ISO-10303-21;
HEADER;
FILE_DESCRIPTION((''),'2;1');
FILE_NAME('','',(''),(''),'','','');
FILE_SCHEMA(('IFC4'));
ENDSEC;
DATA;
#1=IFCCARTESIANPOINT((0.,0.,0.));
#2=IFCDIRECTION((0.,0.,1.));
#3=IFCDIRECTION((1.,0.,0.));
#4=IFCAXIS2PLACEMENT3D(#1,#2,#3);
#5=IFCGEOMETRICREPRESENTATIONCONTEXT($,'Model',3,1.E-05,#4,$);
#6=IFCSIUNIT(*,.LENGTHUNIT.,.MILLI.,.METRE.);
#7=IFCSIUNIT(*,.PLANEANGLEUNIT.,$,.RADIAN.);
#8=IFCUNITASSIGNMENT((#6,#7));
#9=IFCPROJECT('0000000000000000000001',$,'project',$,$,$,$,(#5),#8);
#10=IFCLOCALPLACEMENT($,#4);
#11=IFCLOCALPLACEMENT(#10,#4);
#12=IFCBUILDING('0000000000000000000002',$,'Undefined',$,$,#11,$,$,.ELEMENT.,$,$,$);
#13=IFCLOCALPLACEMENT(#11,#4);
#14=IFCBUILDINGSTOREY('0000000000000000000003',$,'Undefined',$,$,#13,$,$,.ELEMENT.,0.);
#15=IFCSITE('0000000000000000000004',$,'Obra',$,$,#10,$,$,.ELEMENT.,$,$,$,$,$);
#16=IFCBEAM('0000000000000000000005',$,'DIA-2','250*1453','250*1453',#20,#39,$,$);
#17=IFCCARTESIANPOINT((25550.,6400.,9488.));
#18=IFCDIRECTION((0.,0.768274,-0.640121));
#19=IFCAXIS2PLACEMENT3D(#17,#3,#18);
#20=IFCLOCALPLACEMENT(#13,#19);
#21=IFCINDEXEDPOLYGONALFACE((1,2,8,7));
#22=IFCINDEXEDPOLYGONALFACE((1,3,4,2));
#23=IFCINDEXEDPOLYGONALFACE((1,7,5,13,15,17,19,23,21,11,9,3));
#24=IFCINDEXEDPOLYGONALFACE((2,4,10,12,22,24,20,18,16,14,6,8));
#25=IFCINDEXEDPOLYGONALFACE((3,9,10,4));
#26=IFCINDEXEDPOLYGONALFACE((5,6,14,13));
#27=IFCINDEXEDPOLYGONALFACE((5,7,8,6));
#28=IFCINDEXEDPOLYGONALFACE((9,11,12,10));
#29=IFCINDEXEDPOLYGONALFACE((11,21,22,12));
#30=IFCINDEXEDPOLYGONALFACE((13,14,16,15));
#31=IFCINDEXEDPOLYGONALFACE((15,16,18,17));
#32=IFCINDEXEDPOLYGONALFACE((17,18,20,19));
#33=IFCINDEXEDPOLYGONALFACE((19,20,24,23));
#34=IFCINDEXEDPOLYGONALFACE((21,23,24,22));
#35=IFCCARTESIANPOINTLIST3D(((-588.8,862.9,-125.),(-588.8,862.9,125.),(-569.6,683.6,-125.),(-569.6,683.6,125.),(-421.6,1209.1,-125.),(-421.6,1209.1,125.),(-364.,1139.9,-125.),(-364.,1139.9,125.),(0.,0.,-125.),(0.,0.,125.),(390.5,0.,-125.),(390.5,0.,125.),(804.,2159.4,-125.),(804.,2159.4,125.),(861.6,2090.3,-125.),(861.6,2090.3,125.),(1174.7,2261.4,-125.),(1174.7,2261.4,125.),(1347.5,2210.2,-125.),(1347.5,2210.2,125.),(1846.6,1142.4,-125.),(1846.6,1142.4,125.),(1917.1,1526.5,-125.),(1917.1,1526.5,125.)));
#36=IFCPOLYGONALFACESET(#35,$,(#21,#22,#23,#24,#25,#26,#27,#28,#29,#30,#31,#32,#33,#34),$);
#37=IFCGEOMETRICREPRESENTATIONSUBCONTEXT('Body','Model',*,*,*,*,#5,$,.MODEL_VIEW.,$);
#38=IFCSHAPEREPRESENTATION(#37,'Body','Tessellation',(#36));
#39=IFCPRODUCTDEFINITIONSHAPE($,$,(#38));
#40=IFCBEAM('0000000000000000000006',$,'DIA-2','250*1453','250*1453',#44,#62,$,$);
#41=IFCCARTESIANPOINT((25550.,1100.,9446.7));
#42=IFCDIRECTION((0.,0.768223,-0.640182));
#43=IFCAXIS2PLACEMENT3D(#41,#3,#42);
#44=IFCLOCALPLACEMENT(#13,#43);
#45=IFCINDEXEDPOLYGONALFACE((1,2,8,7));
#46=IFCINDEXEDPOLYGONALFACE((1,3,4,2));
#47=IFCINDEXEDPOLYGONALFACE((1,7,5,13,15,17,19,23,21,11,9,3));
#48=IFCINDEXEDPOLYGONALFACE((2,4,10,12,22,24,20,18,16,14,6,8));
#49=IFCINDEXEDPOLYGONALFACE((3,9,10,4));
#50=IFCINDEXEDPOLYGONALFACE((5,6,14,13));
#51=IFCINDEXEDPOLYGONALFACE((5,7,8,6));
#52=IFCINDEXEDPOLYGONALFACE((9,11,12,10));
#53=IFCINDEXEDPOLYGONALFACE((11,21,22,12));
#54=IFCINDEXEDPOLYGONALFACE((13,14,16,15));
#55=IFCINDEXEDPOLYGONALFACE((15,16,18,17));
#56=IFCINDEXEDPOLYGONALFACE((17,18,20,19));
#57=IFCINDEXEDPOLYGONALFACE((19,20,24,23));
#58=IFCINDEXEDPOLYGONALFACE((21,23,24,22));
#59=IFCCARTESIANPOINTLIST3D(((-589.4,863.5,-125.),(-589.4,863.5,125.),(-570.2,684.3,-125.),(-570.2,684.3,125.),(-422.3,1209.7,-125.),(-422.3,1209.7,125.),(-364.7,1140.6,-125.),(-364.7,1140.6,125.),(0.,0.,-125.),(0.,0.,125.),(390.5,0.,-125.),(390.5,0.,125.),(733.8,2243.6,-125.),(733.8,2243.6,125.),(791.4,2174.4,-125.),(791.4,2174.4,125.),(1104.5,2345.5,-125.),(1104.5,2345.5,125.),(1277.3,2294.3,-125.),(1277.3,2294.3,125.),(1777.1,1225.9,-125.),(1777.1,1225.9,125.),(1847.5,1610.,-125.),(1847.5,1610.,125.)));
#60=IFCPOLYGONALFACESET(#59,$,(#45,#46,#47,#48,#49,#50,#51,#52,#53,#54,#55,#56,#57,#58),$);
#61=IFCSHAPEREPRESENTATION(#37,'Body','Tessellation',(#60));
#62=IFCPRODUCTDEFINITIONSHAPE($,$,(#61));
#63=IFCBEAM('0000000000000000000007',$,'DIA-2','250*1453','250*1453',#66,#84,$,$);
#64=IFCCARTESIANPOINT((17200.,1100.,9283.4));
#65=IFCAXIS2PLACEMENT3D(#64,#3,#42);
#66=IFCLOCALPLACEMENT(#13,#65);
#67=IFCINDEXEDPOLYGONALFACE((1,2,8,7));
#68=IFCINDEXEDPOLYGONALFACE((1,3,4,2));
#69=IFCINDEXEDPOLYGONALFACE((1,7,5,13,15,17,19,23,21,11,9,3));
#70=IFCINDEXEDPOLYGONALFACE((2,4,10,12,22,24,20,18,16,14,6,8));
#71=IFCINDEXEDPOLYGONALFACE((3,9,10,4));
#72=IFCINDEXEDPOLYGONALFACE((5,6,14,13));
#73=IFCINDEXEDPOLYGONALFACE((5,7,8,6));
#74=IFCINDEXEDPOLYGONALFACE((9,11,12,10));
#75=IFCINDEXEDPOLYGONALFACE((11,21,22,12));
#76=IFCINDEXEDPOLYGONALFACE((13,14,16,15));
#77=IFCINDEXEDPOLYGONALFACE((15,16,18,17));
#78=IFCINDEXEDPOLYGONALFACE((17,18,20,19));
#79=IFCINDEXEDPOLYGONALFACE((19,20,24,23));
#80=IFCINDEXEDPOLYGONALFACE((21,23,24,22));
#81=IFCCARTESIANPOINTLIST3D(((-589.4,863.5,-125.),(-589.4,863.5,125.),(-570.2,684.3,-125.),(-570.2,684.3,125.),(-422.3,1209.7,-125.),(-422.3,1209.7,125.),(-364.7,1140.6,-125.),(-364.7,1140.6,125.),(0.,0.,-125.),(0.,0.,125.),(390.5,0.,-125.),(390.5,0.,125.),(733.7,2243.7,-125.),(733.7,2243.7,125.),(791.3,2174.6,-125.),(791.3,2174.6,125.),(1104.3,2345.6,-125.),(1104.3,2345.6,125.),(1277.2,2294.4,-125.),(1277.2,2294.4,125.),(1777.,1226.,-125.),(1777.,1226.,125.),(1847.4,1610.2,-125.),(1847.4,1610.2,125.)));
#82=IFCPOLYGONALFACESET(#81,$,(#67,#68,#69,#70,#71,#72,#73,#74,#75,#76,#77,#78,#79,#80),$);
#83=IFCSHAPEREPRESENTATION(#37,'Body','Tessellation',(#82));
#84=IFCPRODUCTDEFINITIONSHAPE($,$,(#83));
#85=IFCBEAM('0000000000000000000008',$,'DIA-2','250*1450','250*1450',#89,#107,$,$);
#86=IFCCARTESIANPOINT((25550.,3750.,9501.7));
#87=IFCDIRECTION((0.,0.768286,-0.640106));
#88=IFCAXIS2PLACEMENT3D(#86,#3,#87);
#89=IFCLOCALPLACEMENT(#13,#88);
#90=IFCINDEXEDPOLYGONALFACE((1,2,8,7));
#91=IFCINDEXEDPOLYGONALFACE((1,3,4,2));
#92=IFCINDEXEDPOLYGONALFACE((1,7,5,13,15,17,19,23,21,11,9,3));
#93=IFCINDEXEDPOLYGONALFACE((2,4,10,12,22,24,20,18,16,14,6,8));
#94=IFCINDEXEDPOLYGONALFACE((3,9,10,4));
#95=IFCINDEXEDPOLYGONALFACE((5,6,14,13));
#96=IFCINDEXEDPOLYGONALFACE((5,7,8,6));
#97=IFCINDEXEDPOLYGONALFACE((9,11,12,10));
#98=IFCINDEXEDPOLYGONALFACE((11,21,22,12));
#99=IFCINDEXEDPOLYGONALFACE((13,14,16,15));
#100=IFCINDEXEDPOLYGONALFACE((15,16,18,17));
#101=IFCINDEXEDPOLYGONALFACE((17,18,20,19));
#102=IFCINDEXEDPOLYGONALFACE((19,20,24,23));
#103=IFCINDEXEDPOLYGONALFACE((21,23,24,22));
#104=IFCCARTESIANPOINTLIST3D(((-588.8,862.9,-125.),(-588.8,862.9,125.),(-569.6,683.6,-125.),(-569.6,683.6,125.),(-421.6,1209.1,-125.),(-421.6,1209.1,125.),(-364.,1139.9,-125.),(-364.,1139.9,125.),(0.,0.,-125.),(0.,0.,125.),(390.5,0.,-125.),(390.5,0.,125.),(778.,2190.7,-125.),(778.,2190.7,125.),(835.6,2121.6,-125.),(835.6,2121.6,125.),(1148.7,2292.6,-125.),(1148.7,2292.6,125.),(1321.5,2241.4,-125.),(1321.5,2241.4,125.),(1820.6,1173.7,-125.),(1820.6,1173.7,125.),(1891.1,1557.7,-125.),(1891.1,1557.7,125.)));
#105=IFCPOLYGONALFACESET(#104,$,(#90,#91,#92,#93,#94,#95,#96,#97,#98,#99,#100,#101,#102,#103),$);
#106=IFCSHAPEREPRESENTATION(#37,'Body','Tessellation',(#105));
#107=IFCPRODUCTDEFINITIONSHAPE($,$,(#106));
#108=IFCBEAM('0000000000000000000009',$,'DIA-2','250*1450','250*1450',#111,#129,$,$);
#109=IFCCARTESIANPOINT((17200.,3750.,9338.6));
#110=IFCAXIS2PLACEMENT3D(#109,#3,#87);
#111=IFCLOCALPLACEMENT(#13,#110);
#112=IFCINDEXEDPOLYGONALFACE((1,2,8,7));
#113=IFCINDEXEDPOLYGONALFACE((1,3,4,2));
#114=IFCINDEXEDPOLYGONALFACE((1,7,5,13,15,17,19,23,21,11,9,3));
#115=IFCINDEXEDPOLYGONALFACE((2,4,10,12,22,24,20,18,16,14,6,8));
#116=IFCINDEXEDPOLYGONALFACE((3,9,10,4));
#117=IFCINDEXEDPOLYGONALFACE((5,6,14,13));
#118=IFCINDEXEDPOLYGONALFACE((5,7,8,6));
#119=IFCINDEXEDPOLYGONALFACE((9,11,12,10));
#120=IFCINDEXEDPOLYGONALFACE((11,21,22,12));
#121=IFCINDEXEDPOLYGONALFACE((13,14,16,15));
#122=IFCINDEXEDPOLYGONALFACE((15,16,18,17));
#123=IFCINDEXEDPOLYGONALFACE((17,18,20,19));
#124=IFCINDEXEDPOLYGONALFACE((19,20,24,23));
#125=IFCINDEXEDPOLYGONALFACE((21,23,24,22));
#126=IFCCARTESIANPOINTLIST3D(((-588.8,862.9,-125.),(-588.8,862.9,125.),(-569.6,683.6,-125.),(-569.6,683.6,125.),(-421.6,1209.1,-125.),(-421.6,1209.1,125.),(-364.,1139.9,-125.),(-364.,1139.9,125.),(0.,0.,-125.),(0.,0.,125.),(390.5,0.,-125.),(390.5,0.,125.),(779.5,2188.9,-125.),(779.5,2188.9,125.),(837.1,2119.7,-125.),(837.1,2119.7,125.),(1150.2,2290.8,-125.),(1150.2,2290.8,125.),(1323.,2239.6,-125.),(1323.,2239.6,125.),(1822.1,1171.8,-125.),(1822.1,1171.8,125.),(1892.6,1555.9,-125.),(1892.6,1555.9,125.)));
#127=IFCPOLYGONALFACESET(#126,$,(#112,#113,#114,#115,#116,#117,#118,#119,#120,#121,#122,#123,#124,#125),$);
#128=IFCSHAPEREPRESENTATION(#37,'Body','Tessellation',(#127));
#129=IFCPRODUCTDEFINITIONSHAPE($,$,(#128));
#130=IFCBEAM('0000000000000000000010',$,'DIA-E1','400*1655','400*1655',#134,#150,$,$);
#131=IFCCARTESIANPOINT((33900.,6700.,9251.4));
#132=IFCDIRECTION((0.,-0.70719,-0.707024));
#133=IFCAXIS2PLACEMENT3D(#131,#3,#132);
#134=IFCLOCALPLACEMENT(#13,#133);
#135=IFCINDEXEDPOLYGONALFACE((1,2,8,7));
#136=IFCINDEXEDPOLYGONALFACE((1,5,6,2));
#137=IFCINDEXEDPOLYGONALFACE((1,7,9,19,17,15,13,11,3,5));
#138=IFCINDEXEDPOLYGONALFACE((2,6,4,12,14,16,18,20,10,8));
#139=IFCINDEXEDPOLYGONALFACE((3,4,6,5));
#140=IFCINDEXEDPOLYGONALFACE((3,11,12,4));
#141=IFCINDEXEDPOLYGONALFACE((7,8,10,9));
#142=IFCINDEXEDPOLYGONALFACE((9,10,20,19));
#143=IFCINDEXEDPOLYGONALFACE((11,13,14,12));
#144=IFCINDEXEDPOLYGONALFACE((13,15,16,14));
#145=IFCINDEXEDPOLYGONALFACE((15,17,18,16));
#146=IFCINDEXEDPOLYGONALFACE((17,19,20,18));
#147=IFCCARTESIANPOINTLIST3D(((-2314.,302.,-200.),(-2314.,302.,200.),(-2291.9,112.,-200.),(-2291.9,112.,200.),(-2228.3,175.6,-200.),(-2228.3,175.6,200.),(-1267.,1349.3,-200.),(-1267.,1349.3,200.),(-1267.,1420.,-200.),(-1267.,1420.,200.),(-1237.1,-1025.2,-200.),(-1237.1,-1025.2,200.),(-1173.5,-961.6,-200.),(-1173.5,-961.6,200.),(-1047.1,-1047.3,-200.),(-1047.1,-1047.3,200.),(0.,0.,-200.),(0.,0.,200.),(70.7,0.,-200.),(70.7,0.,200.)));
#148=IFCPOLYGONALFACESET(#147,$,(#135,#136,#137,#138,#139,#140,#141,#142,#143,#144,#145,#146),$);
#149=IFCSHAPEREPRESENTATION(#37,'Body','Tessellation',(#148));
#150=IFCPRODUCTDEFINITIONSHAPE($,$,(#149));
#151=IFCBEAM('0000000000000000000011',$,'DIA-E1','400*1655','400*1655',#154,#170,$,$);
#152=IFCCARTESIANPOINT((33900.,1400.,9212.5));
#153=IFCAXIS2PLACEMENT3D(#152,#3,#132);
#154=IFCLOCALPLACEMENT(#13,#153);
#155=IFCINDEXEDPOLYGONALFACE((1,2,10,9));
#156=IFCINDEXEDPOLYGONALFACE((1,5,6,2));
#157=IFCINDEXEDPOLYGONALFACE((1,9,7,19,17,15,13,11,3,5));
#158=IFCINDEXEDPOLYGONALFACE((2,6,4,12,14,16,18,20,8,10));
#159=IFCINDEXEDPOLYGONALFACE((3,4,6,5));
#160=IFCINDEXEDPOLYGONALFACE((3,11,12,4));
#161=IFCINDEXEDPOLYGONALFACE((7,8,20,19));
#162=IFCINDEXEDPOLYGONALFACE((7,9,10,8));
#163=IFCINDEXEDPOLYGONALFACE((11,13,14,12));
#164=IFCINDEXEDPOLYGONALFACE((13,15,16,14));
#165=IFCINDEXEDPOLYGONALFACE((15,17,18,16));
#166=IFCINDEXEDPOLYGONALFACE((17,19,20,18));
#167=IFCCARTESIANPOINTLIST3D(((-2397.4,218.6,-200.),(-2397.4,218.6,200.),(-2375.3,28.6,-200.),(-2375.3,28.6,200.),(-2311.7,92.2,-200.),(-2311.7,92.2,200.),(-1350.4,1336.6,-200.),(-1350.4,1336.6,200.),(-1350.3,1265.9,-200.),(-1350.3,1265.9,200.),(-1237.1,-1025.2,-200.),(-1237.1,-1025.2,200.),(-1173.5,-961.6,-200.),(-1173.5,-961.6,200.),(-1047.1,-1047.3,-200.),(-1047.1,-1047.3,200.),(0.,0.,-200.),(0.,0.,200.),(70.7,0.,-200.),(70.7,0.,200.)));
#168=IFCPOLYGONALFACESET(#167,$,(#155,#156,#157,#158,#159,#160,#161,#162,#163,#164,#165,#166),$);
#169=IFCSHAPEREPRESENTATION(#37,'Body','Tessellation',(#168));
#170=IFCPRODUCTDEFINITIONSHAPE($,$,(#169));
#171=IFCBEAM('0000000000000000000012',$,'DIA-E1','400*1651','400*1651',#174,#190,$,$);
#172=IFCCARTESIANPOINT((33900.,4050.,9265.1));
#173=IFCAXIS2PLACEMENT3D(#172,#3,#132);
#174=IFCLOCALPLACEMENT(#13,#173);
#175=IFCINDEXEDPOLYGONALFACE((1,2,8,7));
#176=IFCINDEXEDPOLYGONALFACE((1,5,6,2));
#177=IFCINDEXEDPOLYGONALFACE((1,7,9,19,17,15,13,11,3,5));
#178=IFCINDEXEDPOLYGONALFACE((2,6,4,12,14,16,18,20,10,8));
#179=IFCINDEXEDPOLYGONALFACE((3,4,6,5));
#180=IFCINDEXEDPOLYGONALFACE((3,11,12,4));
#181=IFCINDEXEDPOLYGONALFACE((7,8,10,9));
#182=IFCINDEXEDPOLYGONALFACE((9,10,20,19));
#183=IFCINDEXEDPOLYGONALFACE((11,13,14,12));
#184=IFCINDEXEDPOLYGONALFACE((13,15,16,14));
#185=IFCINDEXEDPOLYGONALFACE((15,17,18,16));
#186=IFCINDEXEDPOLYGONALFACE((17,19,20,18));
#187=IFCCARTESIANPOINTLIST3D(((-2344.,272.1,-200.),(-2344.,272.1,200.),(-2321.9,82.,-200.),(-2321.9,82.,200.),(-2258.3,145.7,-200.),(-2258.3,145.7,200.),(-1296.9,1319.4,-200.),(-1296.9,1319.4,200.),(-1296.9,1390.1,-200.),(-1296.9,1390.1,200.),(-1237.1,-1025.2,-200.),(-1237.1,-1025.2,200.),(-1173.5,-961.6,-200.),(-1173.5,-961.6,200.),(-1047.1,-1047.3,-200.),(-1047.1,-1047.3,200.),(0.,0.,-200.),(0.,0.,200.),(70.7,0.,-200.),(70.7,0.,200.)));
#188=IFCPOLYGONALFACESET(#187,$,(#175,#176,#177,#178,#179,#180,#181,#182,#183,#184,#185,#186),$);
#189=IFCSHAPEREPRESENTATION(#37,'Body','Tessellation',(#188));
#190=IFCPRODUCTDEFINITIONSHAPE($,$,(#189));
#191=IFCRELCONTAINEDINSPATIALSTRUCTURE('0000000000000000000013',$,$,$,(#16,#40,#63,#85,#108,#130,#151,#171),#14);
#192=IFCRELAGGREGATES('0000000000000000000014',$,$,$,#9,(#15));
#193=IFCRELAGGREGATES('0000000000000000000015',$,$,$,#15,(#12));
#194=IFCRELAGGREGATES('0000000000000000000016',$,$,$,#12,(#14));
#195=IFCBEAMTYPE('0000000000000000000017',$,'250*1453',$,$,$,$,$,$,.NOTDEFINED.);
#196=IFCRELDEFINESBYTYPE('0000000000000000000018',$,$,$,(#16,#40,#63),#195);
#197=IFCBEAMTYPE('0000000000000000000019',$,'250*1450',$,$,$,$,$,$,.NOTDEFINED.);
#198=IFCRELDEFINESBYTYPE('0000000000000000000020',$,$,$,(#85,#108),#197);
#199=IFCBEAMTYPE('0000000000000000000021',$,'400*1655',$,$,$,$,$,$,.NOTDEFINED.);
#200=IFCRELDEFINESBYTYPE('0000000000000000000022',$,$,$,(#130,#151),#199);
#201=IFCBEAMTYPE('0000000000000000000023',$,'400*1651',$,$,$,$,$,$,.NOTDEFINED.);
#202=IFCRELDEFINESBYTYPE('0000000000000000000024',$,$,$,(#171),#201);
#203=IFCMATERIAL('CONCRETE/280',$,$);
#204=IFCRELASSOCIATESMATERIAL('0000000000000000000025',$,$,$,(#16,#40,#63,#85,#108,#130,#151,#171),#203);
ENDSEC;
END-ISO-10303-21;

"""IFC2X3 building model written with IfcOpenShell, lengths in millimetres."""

from ifc_helpers import new_model, si_unit, frame, origin_with_axes, place, context, subcontext, project, spatial, polyline, outline, extrude, material, type_object, element, save


model = new_model("IFC2X3")

# Units and contexts
model_context = context("Model", 3, precision=1e-05, world=origin_with_axes())
body_context = subcontext(model_context, "Body", "Model", "MODEL_VIEW")
ifc_project = project(units=[si_unit("LENGTHUNIT", "METRE", prefix="MILLI"), si_unit("PLANEANGLEUNIT", "RADIAN")], contexts=[model_context])

# Site, building, storey
site_placement = place(None, origin_with_axes())
site = spatial("IfcSite", under=ifc_project, at=site_placement, Name="Obra", CompositionType="ELEMENT")
building_placement = place(site_placement, origin_with_axes())
building = spatial("IfcBuilding", under=site, at=building_placement, Name="Undefined", CompositionType="ELEMENT")
storey_placement = place(building_placement, origin_with_axes())
storey = spatial("IfcBuildingStorey", under=building, at=storey_placement, Name="Undefined", CompositionType="ELEMENT", Elevation=0.0)

# Shared definitions
ifc_material_1 = material(Name="CONCRETE/280")

# Beams
beam_type_1 = type_object("IfcBeamType", Name="250*1453", PredefinedType="NOTDEFINED")
beam_1_placement = place(storey_placement, frame((25550.0, 6400.0, 9488.0), z_axis=(1.0, 0.0, 0.0), x_axis=(0.0, 0.768274, -0.640121)))
element("IfcBeam", 1, at=beam_1_placement, inside=storey, type_object=beam_type_1, material=ifc_material_1, Name="DIA-2", Description="250*1453", ObjectType="250*1453", context=body_context, shape_type="SweptSolid", body=[
    extrude(outline(polyline([(0.0, 0.0), (390.5, 0.0), (1846.6, 1142.4), (1917.1, 1526.5), (1347.5, 2210.2), (1174.7, 2261.4), (861.6, 2090.3), (804.0, 2159.4), (-421.6, 1209.1), (-364.0, 1139.9), (-588.8, 862.9), (-569.6, 683.6), (0.0, 0.0)])), frame((0.0, 0.0, -125.0), z_axis=(0.0, 0.0, 1.0), x_axis=(1.0, 0.0, 0.0)), (0.0, 0.0, 1.0), 250.0),
])
beam_2_placement = place(storey_placement, frame((25550.0, 1100.0, 9446.7), z_axis=(1.0, 0.0, 0.0), x_axis=(0.0, 0.768223, -0.640182)))
element("IfcBeam", 2, at=beam_2_placement, inside=storey, type_object=beam_type_1, material=ifc_material_1, Name="DIA-2", Description="250*1453", ObjectType="250*1453", context=body_context, shape_type="SweptSolid", body=[
    extrude(outline(polyline([(0.0, 0.0), (390.5, 0.0), (1777.1, 1225.9), (1847.5, 1610.0), (1277.3, 2294.3), (1104.5, 2345.5), (791.4, 2174.4), (733.8, 2243.6), (-422.3, 1209.7), (-364.7, 1140.6), (-589.4, 863.5), (-570.2, 684.3), (0.0, 0.0)])), frame((0.0, 0.0, -125.0), z_axis=(0.0, 0.0, 1.0), x_axis=(1.0, 0.0, 0.0)), (0.0, 0.0, 1.0), 250.0),
])
beam_3_placement = place(storey_placement, frame((17200.0, 1100.0, 9283.4), z_axis=(1.0, 0.0, 0.0), x_axis=(0.0, 0.768223, -0.640182)))
element("IfcBeam", 3, at=beam_3_placement, inside=storey, type_object=beam_type_1, material=ifc_material_1, Name="DIA-2", Description="250*1453", ObjectType="250*1453", context=body_context, shape_type="SweptSolid", body=[
    extrude(outline(polyline([(0.0, 0.0), (390.5, 0.0), (1777.0, 1226.0), (1847.4, 1610.2), (1277.2, 2294.4), (1104.3, 2345.6), (791.3, 2174.6), (733.7, 2243.7), (-422.3, 1209.7), (-364.7, 1140.6), (-589.4, 863.5), (-570.2, 684.3), (0.0, 0.0)])), frame((0.0, 0.0, -125.0), z_axis=(0.0, 0.0, 1.0), x_axis=(1.0, 0.0, 0.0)), (0.0, 0.0, 1.0), 250.0),
])
beam_type_2 = type_object("IfcBeamType", Name="250*1450", PredefinedType="NOTDEFINED")
beam_4_placement = place(storey_placement, frame((25550.0, 3750.0, 9501.7), z_axis=(1.0, 0.0, 0.0), x_axis=(0.0, 0.768286, -0.640106)))
element("IfcBeam", 4, at=beam_4_placement, inside=storey, type_object=beam_type_2, material=ifc_material_1, Name="DIA-2", Description="250*1450", ObjectType="250*1450", context=body_context, shape_type="SweptSolid", body=[
    extrude(outline(polyline([(0.0, 0.0), (390.5, 0.0), (1820.6, 1173.7), (1891.1, 1557.7), (1321.5, 2241.4), (1148.7, 2292.6), (835.6, 2121.6), (778.0, 2190.7), (-421.6, 1209.1), (-364.0, 1139.9), (-588.8, 862.9), (-569.6, 683.6), (0.0, 0.0)])), frame((0.0, 0.0, -125.0), z_axis=(0.0, 0.0, 1.0), x_axis=(1.0, 0.0, 0.0)), (0.0, 0.0, 1.0), 250.0),
])
beam_5_placement = place(storey_placement, frame((17200.0, 3750.0, 9338.6), z_axis=(1.0, 0.0, 0.0), x_axis=(0.0, 0.768286, -0.640106)))
element("IfcBeam", 5, at=beam_5_placement, inside=storey, type_object=beam_type_2, material=ifc_material_1, Name="DIA-2", Description="250*1450", ObjectType="250*1450", context=body_context, shape_type="SweptSolid", body=[
    extrude(outline(polyline([(0.0, 0.0), (390.5, 0.0), (1822.1, 1171.8), (1892.6, 1555.9), (1323.0, 2239.6), (1150.2, 2290.8), (837.1, 2119.7), (779.5, 2188.9), (-421.6, 1209.1), (-364.0, 1139.9), (-588.8, 862.9), (-569.6, 683.6), (0.0, 0.0)])), frame((0.0, 0.0, -125.0), z_axis=(0.0, 0.0, 1.0), x_axis=(1.0, 0.0, 0.0)), (0.0, 0.0, 1.0), 250.0),
])
beam_type_3 = type_object("IfcBeamType", Name="400*1655", PredefinedType="NOTDEFINED")
beam_6_placement = place(storey_placement, frame((33900.0, 6700.0, 9251.4), z_axis=(1.0, 0.0, 0.0), x_axis=(0.0, -0.70719, -0.707024)))
element("IfcBeam", 6, at=beam_6_placement, inside=storey, type_object=beam_type_3, material=ifc_material_1, Name="DIA-E1", Description="400*1655", ObjectType="400*1655", context=body_context, shape_type="SweptSolid", body=[
    extrude(outline(polyline([(0.0, 0.0), (70.7, 0.0), (-1267.0, 1420.0), (-1267.0, 1349.3), (-2314.0, 302.0), (-2228.3, 175.6), (-2291.9, 112.0), (-1237.1, -1025.2), (-1173.5, -961.6), (-1047.1, -1047.3), (0.0, 0.0)])), frame((0.0, 0.0, -200.0), z_axis=(0.0, 0.0, 1.0), x_axis=(1.0, 0.0, 0.0)), (0.0, 0.0, 1.0), 400.0),
])
beam_7_placement = place(storey_placement, frame((33900.0, 1400.0, 9212.5), z_axis=(1.0, 0.0, 0.0), x_axis=(0.0, -0.70719, -0.707024)))
element("IfcBeam", 7, at=beam_7_placement, inside=storey, type_object=beam_type_3, material=ifc_material_1, Name="DIA-E1", Description="400*1655", ObjectType="400*1655", context=body_context, shape_type="SweptSolid", body=[
    extrude(outline(polyline([(0.0, 0.0), (70.7, 0.0), (-1350.4, 1336.6), (-1350.3, 1265.9), (-2397.4, 218.6), (-2311.7, 92.2), (-2375.3, 28.6), (-1237.1, -1025.2), (-1173.5, -961.6), (-1047.1, -1047.3), (0.0, 0.0)])), frame((0.0, 0.0, -200.0), z_axis=(0.0, 0.0, 1.0), x_axis=(1.0, 0.0, 0.0)), (0.0, 0.0, 1.0), 400.0),
])
beam_type_4 = type_object("IfcBeamType", Name="400*1651", PredefinedType="NOTDEFINED")
beam_8_placement = place(storey_placement, frame((33900.0, 4050.0, 9265.1), z_axis=(1.0, 0.0, 0.0), x_axis=(0.0, -0.70719, -0.707024)))
element("IfcBeam", 8, at=beam_8_placement, inside=storey, type_object=beam_type_4, material=ifc_material_1, Name="DIA-E1", Description="400*1651", ObjectType="400*1651", context=body_context, shape_type="SweptSolid", body=[
    extrude(outline(polyline([(0.0, 0.0), (70.7, 0.0), (-1296.9, 1390.1), (-1296.9, 1319.4), (-2344.0, 272.1), (-2258.3, 145.7), (-2321.9, 82.0), (-1237.1, -1025.2), (-1173.5, -961.6), (-1047.1, -1047.3), (0.0, 0.0)])), frame((0.0, 0.0, -200.0), z_axis=(0.0, 0.0, 1.0), x_axis=(1.0, 0.0, 0.0)), (0.0, 0.0, 1.0), 400.0),
])

save(model, "model.ifc")
